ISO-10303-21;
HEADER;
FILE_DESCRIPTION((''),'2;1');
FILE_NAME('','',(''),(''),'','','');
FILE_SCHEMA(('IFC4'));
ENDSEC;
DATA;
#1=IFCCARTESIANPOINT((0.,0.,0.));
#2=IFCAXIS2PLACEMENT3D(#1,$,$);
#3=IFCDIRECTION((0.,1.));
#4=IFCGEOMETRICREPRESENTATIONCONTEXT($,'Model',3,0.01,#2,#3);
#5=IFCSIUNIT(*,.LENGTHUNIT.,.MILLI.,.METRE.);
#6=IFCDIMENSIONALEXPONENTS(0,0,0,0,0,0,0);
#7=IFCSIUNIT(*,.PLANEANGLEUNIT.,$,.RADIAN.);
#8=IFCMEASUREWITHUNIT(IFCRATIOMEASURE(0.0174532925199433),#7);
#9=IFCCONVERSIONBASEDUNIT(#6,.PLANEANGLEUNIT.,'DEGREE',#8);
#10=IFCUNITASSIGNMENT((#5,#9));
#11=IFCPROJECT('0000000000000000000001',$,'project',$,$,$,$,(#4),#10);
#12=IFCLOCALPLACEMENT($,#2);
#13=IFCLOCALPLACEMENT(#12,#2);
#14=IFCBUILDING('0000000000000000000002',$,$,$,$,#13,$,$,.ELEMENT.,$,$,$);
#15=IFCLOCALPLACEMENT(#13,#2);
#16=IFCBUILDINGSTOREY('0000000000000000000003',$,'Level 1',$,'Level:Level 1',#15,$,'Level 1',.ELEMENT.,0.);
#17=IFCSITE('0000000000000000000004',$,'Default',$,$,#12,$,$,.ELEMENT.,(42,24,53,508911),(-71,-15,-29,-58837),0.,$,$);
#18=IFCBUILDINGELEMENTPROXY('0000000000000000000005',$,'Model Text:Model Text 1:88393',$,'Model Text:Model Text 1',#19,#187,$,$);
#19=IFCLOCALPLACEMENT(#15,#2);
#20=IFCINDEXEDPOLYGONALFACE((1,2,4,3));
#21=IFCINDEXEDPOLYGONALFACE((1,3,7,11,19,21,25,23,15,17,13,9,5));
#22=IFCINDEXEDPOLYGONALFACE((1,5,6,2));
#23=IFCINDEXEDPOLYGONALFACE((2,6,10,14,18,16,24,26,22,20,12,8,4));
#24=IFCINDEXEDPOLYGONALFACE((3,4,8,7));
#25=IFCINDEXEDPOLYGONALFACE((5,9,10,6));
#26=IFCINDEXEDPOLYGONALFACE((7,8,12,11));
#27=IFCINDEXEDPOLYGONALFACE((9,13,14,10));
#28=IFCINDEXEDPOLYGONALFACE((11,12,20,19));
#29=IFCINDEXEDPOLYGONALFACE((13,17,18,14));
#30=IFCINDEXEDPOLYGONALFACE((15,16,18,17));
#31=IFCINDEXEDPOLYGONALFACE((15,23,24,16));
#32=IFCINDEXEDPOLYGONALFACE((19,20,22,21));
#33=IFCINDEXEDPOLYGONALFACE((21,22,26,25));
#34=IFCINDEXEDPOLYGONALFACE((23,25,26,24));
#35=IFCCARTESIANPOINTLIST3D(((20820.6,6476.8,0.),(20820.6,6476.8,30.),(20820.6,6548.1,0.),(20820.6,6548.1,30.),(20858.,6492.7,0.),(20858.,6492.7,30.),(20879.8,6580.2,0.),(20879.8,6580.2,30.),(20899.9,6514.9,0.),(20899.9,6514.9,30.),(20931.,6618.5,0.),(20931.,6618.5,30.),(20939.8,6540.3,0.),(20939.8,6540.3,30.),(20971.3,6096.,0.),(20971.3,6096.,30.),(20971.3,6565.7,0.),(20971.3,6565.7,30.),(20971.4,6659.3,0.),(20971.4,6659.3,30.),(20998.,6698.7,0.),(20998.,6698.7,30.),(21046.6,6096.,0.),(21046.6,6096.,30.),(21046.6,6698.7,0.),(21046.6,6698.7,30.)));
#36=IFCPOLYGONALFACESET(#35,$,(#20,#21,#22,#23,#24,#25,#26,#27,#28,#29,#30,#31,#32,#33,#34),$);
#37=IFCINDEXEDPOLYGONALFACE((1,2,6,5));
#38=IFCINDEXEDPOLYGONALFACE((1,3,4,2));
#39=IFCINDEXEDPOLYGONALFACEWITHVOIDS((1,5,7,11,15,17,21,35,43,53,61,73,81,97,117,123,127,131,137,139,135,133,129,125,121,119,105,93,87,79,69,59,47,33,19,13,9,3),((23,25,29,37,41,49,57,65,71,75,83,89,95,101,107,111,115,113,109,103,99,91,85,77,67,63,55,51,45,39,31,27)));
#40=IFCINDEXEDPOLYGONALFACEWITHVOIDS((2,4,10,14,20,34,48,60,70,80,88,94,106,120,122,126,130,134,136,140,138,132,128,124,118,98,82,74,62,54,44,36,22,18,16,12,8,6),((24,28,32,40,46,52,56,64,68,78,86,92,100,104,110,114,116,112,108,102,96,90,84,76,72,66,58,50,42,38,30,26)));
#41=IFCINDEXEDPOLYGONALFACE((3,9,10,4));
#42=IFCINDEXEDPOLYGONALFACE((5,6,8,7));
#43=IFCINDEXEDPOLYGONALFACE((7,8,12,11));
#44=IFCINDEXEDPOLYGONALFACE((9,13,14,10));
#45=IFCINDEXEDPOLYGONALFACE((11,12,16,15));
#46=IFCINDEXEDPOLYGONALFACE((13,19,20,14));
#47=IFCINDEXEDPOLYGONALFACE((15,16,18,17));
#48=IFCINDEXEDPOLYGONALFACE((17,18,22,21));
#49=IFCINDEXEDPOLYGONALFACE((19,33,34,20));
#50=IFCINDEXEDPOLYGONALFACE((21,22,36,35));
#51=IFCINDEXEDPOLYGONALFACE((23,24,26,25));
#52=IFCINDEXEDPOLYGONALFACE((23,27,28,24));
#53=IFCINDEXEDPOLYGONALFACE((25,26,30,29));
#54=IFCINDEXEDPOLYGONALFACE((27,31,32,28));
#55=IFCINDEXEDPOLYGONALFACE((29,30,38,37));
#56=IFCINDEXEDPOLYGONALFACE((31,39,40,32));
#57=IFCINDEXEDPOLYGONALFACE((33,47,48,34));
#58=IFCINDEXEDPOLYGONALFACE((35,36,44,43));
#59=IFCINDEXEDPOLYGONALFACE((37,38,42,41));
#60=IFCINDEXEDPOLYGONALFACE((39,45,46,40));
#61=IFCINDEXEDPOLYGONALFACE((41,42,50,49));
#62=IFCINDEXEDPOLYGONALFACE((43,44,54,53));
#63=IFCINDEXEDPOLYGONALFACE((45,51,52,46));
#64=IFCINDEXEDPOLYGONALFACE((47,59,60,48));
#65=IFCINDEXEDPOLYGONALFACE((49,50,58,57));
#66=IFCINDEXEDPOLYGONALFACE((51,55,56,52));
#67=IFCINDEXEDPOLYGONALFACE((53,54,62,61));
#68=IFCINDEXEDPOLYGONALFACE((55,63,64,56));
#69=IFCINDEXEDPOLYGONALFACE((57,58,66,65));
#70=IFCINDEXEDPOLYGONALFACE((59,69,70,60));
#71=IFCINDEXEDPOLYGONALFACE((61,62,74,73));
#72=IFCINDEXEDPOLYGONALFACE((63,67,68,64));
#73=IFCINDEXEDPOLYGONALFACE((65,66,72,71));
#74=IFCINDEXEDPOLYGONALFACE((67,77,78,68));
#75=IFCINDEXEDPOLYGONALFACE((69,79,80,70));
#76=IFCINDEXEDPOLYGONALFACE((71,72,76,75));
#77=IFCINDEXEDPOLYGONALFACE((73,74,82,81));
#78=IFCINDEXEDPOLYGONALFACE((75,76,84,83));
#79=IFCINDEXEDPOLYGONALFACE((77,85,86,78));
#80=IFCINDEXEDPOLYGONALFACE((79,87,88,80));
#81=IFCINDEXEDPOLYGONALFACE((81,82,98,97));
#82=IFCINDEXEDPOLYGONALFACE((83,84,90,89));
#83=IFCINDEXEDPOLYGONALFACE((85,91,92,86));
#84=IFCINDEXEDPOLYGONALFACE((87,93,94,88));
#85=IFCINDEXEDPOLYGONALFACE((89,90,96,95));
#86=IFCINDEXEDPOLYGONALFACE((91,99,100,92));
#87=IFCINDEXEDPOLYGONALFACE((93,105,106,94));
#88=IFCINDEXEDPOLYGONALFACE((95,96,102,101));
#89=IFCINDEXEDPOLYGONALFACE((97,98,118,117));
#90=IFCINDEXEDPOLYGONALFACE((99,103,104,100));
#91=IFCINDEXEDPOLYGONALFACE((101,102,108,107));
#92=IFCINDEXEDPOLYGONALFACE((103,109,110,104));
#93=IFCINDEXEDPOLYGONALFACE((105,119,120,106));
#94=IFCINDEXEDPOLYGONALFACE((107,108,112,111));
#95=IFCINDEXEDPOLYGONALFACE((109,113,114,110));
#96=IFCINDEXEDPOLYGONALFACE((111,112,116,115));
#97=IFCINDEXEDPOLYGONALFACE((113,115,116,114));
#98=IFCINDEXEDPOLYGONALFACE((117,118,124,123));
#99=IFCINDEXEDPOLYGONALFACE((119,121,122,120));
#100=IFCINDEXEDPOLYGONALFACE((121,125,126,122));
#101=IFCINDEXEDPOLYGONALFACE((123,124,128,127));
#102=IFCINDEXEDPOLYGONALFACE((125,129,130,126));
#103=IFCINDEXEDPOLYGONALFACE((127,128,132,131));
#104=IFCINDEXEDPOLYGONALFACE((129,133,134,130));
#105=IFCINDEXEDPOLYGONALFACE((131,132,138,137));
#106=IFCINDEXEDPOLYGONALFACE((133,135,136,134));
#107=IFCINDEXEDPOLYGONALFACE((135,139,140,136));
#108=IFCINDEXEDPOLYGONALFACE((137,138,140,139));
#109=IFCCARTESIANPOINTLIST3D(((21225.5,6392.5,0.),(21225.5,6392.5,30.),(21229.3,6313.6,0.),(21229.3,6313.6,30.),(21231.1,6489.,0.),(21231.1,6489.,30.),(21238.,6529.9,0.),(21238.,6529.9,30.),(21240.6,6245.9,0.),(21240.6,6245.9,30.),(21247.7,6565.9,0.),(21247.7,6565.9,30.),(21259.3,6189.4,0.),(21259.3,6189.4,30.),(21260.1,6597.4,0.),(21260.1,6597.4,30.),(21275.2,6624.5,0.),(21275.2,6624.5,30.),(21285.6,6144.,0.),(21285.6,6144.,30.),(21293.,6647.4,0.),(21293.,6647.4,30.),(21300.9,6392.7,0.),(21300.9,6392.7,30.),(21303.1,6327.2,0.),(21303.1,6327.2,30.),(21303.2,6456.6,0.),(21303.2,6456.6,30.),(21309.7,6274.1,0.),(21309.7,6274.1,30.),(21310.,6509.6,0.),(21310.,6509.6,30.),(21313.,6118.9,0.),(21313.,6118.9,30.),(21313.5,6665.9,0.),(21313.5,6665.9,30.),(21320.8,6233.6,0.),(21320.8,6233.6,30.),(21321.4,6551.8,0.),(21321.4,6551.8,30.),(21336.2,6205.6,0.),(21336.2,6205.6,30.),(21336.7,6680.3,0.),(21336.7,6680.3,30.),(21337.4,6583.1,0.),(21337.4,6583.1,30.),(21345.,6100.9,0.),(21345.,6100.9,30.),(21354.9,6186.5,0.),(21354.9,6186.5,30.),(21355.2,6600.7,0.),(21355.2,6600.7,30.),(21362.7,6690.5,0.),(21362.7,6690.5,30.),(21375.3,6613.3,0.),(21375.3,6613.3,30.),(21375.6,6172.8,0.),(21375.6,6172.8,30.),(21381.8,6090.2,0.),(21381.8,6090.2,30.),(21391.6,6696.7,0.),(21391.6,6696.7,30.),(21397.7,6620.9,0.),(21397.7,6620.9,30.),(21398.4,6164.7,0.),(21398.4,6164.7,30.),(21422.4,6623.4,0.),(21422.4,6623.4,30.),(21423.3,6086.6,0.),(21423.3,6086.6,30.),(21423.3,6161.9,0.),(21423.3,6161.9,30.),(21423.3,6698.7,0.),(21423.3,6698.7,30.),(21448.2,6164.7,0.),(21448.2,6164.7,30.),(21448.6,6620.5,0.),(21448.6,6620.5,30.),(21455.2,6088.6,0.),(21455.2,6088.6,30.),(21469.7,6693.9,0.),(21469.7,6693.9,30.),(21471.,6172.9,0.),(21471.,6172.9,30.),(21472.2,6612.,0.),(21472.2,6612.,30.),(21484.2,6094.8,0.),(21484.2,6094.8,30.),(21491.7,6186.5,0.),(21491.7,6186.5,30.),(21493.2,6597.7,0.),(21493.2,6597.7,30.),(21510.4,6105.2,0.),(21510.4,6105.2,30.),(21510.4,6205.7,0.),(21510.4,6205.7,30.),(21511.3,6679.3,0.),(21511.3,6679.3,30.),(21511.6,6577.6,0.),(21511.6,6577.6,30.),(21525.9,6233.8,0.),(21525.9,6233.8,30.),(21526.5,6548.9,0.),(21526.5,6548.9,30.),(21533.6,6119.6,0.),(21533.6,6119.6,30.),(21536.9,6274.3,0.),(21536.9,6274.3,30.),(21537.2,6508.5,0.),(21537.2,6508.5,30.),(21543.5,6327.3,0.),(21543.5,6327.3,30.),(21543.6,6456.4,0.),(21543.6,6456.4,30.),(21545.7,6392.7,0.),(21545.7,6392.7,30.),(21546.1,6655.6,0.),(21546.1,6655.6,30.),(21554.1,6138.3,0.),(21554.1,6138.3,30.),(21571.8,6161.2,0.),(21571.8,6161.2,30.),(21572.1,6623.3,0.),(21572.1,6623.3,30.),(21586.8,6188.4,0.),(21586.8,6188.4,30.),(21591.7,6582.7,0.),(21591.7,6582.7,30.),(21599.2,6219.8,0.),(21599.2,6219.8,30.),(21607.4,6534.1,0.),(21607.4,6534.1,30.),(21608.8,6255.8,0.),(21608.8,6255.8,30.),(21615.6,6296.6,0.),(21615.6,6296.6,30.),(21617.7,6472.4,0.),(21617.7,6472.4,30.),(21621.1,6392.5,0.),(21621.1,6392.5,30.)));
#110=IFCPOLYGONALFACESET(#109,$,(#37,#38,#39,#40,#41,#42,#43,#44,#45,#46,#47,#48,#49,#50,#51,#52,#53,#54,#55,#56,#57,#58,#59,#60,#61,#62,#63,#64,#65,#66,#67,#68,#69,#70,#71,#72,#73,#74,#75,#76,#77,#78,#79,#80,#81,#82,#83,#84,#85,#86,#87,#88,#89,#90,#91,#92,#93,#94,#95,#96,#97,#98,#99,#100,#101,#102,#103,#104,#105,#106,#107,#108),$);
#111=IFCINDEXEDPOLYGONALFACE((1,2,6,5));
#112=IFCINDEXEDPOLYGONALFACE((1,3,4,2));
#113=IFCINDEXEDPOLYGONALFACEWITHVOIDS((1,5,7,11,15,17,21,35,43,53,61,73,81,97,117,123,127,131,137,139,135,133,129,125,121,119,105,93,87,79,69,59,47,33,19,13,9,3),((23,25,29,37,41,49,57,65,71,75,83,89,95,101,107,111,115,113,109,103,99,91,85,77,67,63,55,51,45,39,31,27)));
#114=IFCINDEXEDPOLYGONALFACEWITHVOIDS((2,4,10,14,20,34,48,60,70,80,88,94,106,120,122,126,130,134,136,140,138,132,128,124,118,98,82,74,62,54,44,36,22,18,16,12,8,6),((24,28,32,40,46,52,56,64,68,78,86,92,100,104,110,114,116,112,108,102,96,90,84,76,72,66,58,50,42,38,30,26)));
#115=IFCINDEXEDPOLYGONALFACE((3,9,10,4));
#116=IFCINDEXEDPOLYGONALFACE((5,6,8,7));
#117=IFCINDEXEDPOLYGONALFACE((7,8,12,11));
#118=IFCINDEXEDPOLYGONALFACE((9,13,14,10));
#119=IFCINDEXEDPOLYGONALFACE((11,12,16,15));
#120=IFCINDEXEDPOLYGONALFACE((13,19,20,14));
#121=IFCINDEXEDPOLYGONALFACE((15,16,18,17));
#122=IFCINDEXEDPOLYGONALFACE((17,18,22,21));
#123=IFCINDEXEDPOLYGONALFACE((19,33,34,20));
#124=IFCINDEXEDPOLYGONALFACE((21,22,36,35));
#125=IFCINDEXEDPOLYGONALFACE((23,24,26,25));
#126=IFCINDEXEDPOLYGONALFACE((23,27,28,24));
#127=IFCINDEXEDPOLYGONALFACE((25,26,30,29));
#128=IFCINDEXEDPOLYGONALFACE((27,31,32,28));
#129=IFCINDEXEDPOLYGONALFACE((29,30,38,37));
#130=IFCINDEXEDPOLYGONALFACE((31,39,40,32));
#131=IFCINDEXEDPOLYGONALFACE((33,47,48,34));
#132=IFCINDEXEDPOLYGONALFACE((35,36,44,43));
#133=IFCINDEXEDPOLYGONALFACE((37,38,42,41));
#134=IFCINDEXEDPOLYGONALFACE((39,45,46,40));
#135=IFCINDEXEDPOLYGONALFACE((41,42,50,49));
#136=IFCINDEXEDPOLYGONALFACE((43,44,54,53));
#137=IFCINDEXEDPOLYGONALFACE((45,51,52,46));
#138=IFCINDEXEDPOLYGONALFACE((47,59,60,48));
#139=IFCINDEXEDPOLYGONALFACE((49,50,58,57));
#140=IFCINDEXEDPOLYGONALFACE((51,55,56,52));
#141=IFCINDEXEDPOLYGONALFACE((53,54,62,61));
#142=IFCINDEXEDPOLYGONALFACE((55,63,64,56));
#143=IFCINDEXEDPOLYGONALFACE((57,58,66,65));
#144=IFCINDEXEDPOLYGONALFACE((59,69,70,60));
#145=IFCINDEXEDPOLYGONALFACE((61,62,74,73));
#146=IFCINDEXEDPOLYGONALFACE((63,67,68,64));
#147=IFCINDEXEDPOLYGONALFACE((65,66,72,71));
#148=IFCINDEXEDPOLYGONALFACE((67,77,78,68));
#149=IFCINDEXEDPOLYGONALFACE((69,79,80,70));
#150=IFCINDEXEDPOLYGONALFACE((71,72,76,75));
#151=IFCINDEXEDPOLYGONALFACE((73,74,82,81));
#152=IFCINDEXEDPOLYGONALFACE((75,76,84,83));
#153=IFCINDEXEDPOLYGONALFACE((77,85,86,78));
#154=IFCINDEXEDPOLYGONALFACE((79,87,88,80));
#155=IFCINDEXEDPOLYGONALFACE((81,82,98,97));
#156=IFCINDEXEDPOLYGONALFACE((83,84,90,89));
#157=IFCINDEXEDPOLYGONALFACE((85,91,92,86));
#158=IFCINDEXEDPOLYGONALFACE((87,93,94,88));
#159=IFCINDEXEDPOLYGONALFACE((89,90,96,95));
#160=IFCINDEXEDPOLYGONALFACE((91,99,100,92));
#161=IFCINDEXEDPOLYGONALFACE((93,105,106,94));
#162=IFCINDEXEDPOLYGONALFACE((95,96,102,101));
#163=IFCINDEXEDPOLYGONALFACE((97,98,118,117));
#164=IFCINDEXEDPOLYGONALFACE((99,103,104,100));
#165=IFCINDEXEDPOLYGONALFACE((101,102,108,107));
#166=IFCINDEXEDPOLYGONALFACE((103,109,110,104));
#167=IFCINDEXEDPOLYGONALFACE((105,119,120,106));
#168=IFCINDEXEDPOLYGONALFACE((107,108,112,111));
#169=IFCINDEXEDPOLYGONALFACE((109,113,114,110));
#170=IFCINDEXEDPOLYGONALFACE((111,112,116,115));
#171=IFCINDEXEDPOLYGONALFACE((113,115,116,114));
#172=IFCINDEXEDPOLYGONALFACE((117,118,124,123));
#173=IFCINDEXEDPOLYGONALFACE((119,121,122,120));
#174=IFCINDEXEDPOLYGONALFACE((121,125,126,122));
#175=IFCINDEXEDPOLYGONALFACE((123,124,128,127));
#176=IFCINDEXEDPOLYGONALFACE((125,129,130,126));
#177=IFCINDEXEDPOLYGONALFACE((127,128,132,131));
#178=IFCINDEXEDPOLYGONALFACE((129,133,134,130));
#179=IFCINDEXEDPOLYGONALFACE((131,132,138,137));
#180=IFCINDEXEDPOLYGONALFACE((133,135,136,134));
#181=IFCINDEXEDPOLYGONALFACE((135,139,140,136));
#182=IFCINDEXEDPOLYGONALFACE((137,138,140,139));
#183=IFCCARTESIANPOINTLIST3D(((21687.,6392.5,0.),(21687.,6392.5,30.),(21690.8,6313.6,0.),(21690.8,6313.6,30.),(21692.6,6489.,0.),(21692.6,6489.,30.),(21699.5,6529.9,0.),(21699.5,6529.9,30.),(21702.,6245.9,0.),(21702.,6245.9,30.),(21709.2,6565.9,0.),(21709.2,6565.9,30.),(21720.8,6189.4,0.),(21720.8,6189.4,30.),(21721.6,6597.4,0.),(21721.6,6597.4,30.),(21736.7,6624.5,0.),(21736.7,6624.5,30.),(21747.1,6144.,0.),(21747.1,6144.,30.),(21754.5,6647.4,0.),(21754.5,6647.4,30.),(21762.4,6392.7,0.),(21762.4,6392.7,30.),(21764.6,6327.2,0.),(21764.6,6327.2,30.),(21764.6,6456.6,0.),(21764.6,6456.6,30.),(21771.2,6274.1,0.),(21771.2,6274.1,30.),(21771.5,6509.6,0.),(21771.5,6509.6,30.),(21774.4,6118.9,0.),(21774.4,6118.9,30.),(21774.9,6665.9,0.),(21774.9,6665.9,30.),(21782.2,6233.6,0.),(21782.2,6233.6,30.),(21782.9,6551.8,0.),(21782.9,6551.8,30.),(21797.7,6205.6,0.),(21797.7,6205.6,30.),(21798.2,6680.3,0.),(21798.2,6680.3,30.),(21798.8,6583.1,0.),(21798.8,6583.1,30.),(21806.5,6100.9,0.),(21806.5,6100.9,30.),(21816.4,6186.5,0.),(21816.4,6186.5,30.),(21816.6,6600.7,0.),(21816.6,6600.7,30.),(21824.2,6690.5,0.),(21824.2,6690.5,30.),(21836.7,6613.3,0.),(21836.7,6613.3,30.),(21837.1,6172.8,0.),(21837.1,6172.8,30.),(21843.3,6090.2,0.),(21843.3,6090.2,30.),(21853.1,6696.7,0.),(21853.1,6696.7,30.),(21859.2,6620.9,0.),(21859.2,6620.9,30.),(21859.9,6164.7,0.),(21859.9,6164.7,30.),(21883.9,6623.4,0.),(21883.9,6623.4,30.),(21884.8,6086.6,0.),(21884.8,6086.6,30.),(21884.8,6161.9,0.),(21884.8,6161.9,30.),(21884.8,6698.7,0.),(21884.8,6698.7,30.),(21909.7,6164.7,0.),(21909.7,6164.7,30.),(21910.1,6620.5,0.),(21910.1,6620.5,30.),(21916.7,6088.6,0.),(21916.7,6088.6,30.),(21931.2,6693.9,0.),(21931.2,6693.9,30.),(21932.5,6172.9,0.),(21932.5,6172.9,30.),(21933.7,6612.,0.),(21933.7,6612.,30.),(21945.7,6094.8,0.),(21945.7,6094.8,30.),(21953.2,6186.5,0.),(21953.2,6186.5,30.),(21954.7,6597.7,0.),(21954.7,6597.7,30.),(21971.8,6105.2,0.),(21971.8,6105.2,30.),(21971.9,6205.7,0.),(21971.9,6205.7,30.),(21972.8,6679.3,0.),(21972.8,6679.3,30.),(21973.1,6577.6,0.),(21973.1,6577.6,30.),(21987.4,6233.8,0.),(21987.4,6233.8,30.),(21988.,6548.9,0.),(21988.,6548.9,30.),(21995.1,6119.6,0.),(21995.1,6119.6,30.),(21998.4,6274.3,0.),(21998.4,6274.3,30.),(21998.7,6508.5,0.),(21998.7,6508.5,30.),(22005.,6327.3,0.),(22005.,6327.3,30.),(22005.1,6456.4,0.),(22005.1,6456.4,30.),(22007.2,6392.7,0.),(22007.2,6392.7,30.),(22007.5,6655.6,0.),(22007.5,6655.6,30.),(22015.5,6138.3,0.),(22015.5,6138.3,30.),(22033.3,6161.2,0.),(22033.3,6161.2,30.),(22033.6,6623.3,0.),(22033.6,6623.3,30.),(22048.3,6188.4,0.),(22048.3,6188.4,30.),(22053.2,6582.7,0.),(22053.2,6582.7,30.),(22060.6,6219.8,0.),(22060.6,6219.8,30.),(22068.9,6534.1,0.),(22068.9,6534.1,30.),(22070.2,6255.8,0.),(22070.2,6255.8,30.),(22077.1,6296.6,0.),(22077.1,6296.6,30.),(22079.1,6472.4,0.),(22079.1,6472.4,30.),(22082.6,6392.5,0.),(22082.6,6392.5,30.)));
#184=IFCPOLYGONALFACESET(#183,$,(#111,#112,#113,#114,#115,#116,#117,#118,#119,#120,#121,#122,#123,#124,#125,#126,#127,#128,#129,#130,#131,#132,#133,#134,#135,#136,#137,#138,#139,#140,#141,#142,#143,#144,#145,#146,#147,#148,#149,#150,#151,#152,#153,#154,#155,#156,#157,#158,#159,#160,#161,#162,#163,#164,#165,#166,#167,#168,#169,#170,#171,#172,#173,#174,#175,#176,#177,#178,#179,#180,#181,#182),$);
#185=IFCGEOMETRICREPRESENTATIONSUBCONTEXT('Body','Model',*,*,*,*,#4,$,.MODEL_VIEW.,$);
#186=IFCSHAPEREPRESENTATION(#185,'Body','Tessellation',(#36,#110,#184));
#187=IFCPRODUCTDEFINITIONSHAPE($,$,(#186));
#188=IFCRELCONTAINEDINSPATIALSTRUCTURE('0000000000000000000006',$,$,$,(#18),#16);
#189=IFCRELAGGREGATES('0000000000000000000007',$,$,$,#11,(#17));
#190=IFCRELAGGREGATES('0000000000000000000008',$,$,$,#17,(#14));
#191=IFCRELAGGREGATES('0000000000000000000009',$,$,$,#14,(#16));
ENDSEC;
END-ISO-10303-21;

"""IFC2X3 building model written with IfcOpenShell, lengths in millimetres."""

from ifc_helpers import new_model, entity, si_unit, converted_unit, direction, frame, origin, place, context, subcontext, project, spatial, polyline, outline, extrude, element, save


model = new_model("IFC2X3")

# Units and contexts
model_context = context("Model", 3, precision=0.01, world=origin(), true_north=direction((0.0, 1.0)))
body_context = subcontext(model_context, "Body", "Model", "MODEL_VIEW")
ifc_project = project(units=[si_unit("LENGTHUNIT", "METRE", prefix="MILLI"), converted_unit("PLANEANGLEUNIT", "DEGREE", entity("IfcRatioMeasure", 0.0174532925199433), si_unit("PLANEANGLEUNIT", "RADIAN"), dimensions=[0, 0, 0, 0, 0, 0, 0])], contexts=[model_context])

# Site, building, storey
site_placement = place(None, origin())
site = spatial("IfcSite", under=ifc_project, at=site_placement, Name="Default", CompositionType="ELEMENT", RefLatitude=(42, 24, 53, 508911), RefLongitude=(-71, -15, -29, -58837), RefElevation=0.0)
building_placement = place(site_placement, origin())
building = spatial("IfcBuilding", under=site, at=building_placement, CompositionType="ELEMENT")
storey_placement = place(building_placement, origin())
storey = spatial("IfcBuildingStorey", under=building, at=storey_placement, Name="Level 1", ObjectType="Level:Level 1", LongName="Level 1", CompositionType="ELEMENT", Elevation=0.0)

# Building element proxy
proxy_1_placement = place(storey_placement, origin())
element("IfcBuildingElementProxy", 1, at=proxy_1_placement, inside=storey, Name="Model Text:Model Text 1:88393", ObjectType="Model Text:Model Text 1", context=body_context, shape_type="SweptSolid", body=[
    extrude(outline(polyline([(-410.6, -111.6), (192.1, -111.6), (192.1, -63.1), (152.7, -36.4), (111.9, 4.0), (73.6, 55.2), (41.4, 114.4), (-29.8, 114.4), (-13.9, 77.0), (8.3, 35.1), (33.7, -4.8), (59.1, -36.3), (-410.6, -36.3), (-410.6, -111.6)])), frame((20935.0, 6506.6, 0.0), z_axis=(0.0, 0.0, 1.0), x_axis=(0.0, 1.0, 0.0)), (0.0, 0.0, 1.0), 30.0),
    extrude(outline(polyline([(-10.6, -198.7), (68.3, -198.7), (136.5, -190.7), (193.9, -174.7), (240.5, -150.6), (266.9, -124.4), (286.3, -93.2), (298.8, -57.0), (304.3, -15.7), (303.8, 16.2), (299.0, 45.5), (289.9, 72.1), (276.6, 96.0), (258.9, 117.3), (236.9, 136.2), (210.4, 152.5), (179.6, 166.3), (144.1, 177.6), (103.7, 186.3), (8.2, 196.4), (-71.8, 196.7), (-134.0, 189.4), (-183.3, 176.1), (-224.7, 158.4), (-258.2, 133.9), (-283.5, 100.3), (-300.1, 59.5), (-307.1, 13.4), (-306.6, -18.4), (-301.8, -47.5), (-292.8, -74.0), (-279.6, -97.9), (-262.0, -119.2), (-240.0, -138.1), (-213.6, -154.5), (-182.8, -168.4), (-147.3, -179.8), (-106.7, -188.6), (-10.6, -198.7)]), holes=[polyline([(-7.2, -123.5), (-71.0, -118.2), (-123.6, -108.8), (-165.2, -95.4), (-195.7, -78.0), (-212.4, -59.4), (-224.1, -38.7), (-230.6, -15.9), (-231.9, 8.9), (-227.8, 35.0), (-218.1, 58.1), (-202.8, 78.4), (-182.0, 95.8), (-152.6, 109.4), (-111.7, 118.1), (-59.4, 122.0), (4.4, 121.1), (69.6, 115.8), (122.2, 106.7), (162.2, 93.7), (189.5, 77.0), (207.7, 57.4), (220.4, 36.0), (227.5, 12.8), (229.1, -12.1), (225.2, -36.8), (215.9, -59.2), (201.3, -79.3), (181.4, -97.1), (152.6, -111.2), (111.6, -120.3), (58.3, -124.4), (-7.2, -123.5)])]), frame((21424.6, 6391.3, 0.0), z_axis=(0.0, 0.0, 1.0), x_axis=(0.047515, -0.998871, 0.0)), (0.0, 0.0, 1.0), 30.0),
    extrude(outline(polyline([(-10.6, -198.7), (68.3, -198.7), (136.5, -190.7), (193.9, -174.7), (240.5, -150.6), (266.9, -124.4), (286.3, -93.2), (298.8, -57.0), (304.3, -15.7), (303.8, 16.2), (299.0, 45.5), (289.9, 72.1), (276.6, 96.0), (258.9, 117.3), (236.9, 136.2), (210.4, 152.5), (179.6, 166.3), (144.1, 177.6), (103.7, 186.3), (8.2, 196.4), (-71.8, 196.7), (-134.0, 189.4), (-183.3, 176.1), (-224.7, 158.4), (-258.2, 133.9), (-283.5, 100.3), (-300.1, 59.5), (-307.1, 13.4), (-306.6, -18.4), (-301.8, -47.5), (-292.8, -74.0), (-279.6, -97.9), (-262.0, -119.2), (-240.0, -138.1), (-213.6, -154.5), (-182.8, -168.4), (-147.3, -179.8), (-106.7, -188.6), (-10.6, -198.7)]), holes=[polyline([(-7.2, -123.5), (-71.0, -118.2), (-123.6, -108.8), (-165.2, -95.4), (-195.7, -78.0), (-212.4, -59.4), (-224.1, -38.7), (-230.6, -15.9), (-231.9, 8.9), (-227.8, 35.0), (-218.1, 58.1), (-202.8, 78.4), (-182.0, 95.8), (-152.6, 109.4), (-111.7, 118.1), (-59.4, 122.0), (4.4, 121.1), (69.6, 115.8), (122.2, 106.7), (162.2, 93.7), (189.5, 77.0), (207.7, 57.4), (220.4, 36.0), (227.5, 12.8), (229.1, -12.1), (225.2, -36.8), (215.9, -59.2), (201.3, -79.3), (181.4, -97.1), (152.6, -111.2), (111.6, -120.3), (58.3, -124.4), (-7.2, -123.5)])]), frame((21886.0, 6391.3, 0.0), z_axis=(0.0, 0.0, 1.0), x_axis=(0.047515, -0.998871, 0.0)), (0.0, 0.0, 1.0), 30.0),
])

save(model, "model.ifc")
